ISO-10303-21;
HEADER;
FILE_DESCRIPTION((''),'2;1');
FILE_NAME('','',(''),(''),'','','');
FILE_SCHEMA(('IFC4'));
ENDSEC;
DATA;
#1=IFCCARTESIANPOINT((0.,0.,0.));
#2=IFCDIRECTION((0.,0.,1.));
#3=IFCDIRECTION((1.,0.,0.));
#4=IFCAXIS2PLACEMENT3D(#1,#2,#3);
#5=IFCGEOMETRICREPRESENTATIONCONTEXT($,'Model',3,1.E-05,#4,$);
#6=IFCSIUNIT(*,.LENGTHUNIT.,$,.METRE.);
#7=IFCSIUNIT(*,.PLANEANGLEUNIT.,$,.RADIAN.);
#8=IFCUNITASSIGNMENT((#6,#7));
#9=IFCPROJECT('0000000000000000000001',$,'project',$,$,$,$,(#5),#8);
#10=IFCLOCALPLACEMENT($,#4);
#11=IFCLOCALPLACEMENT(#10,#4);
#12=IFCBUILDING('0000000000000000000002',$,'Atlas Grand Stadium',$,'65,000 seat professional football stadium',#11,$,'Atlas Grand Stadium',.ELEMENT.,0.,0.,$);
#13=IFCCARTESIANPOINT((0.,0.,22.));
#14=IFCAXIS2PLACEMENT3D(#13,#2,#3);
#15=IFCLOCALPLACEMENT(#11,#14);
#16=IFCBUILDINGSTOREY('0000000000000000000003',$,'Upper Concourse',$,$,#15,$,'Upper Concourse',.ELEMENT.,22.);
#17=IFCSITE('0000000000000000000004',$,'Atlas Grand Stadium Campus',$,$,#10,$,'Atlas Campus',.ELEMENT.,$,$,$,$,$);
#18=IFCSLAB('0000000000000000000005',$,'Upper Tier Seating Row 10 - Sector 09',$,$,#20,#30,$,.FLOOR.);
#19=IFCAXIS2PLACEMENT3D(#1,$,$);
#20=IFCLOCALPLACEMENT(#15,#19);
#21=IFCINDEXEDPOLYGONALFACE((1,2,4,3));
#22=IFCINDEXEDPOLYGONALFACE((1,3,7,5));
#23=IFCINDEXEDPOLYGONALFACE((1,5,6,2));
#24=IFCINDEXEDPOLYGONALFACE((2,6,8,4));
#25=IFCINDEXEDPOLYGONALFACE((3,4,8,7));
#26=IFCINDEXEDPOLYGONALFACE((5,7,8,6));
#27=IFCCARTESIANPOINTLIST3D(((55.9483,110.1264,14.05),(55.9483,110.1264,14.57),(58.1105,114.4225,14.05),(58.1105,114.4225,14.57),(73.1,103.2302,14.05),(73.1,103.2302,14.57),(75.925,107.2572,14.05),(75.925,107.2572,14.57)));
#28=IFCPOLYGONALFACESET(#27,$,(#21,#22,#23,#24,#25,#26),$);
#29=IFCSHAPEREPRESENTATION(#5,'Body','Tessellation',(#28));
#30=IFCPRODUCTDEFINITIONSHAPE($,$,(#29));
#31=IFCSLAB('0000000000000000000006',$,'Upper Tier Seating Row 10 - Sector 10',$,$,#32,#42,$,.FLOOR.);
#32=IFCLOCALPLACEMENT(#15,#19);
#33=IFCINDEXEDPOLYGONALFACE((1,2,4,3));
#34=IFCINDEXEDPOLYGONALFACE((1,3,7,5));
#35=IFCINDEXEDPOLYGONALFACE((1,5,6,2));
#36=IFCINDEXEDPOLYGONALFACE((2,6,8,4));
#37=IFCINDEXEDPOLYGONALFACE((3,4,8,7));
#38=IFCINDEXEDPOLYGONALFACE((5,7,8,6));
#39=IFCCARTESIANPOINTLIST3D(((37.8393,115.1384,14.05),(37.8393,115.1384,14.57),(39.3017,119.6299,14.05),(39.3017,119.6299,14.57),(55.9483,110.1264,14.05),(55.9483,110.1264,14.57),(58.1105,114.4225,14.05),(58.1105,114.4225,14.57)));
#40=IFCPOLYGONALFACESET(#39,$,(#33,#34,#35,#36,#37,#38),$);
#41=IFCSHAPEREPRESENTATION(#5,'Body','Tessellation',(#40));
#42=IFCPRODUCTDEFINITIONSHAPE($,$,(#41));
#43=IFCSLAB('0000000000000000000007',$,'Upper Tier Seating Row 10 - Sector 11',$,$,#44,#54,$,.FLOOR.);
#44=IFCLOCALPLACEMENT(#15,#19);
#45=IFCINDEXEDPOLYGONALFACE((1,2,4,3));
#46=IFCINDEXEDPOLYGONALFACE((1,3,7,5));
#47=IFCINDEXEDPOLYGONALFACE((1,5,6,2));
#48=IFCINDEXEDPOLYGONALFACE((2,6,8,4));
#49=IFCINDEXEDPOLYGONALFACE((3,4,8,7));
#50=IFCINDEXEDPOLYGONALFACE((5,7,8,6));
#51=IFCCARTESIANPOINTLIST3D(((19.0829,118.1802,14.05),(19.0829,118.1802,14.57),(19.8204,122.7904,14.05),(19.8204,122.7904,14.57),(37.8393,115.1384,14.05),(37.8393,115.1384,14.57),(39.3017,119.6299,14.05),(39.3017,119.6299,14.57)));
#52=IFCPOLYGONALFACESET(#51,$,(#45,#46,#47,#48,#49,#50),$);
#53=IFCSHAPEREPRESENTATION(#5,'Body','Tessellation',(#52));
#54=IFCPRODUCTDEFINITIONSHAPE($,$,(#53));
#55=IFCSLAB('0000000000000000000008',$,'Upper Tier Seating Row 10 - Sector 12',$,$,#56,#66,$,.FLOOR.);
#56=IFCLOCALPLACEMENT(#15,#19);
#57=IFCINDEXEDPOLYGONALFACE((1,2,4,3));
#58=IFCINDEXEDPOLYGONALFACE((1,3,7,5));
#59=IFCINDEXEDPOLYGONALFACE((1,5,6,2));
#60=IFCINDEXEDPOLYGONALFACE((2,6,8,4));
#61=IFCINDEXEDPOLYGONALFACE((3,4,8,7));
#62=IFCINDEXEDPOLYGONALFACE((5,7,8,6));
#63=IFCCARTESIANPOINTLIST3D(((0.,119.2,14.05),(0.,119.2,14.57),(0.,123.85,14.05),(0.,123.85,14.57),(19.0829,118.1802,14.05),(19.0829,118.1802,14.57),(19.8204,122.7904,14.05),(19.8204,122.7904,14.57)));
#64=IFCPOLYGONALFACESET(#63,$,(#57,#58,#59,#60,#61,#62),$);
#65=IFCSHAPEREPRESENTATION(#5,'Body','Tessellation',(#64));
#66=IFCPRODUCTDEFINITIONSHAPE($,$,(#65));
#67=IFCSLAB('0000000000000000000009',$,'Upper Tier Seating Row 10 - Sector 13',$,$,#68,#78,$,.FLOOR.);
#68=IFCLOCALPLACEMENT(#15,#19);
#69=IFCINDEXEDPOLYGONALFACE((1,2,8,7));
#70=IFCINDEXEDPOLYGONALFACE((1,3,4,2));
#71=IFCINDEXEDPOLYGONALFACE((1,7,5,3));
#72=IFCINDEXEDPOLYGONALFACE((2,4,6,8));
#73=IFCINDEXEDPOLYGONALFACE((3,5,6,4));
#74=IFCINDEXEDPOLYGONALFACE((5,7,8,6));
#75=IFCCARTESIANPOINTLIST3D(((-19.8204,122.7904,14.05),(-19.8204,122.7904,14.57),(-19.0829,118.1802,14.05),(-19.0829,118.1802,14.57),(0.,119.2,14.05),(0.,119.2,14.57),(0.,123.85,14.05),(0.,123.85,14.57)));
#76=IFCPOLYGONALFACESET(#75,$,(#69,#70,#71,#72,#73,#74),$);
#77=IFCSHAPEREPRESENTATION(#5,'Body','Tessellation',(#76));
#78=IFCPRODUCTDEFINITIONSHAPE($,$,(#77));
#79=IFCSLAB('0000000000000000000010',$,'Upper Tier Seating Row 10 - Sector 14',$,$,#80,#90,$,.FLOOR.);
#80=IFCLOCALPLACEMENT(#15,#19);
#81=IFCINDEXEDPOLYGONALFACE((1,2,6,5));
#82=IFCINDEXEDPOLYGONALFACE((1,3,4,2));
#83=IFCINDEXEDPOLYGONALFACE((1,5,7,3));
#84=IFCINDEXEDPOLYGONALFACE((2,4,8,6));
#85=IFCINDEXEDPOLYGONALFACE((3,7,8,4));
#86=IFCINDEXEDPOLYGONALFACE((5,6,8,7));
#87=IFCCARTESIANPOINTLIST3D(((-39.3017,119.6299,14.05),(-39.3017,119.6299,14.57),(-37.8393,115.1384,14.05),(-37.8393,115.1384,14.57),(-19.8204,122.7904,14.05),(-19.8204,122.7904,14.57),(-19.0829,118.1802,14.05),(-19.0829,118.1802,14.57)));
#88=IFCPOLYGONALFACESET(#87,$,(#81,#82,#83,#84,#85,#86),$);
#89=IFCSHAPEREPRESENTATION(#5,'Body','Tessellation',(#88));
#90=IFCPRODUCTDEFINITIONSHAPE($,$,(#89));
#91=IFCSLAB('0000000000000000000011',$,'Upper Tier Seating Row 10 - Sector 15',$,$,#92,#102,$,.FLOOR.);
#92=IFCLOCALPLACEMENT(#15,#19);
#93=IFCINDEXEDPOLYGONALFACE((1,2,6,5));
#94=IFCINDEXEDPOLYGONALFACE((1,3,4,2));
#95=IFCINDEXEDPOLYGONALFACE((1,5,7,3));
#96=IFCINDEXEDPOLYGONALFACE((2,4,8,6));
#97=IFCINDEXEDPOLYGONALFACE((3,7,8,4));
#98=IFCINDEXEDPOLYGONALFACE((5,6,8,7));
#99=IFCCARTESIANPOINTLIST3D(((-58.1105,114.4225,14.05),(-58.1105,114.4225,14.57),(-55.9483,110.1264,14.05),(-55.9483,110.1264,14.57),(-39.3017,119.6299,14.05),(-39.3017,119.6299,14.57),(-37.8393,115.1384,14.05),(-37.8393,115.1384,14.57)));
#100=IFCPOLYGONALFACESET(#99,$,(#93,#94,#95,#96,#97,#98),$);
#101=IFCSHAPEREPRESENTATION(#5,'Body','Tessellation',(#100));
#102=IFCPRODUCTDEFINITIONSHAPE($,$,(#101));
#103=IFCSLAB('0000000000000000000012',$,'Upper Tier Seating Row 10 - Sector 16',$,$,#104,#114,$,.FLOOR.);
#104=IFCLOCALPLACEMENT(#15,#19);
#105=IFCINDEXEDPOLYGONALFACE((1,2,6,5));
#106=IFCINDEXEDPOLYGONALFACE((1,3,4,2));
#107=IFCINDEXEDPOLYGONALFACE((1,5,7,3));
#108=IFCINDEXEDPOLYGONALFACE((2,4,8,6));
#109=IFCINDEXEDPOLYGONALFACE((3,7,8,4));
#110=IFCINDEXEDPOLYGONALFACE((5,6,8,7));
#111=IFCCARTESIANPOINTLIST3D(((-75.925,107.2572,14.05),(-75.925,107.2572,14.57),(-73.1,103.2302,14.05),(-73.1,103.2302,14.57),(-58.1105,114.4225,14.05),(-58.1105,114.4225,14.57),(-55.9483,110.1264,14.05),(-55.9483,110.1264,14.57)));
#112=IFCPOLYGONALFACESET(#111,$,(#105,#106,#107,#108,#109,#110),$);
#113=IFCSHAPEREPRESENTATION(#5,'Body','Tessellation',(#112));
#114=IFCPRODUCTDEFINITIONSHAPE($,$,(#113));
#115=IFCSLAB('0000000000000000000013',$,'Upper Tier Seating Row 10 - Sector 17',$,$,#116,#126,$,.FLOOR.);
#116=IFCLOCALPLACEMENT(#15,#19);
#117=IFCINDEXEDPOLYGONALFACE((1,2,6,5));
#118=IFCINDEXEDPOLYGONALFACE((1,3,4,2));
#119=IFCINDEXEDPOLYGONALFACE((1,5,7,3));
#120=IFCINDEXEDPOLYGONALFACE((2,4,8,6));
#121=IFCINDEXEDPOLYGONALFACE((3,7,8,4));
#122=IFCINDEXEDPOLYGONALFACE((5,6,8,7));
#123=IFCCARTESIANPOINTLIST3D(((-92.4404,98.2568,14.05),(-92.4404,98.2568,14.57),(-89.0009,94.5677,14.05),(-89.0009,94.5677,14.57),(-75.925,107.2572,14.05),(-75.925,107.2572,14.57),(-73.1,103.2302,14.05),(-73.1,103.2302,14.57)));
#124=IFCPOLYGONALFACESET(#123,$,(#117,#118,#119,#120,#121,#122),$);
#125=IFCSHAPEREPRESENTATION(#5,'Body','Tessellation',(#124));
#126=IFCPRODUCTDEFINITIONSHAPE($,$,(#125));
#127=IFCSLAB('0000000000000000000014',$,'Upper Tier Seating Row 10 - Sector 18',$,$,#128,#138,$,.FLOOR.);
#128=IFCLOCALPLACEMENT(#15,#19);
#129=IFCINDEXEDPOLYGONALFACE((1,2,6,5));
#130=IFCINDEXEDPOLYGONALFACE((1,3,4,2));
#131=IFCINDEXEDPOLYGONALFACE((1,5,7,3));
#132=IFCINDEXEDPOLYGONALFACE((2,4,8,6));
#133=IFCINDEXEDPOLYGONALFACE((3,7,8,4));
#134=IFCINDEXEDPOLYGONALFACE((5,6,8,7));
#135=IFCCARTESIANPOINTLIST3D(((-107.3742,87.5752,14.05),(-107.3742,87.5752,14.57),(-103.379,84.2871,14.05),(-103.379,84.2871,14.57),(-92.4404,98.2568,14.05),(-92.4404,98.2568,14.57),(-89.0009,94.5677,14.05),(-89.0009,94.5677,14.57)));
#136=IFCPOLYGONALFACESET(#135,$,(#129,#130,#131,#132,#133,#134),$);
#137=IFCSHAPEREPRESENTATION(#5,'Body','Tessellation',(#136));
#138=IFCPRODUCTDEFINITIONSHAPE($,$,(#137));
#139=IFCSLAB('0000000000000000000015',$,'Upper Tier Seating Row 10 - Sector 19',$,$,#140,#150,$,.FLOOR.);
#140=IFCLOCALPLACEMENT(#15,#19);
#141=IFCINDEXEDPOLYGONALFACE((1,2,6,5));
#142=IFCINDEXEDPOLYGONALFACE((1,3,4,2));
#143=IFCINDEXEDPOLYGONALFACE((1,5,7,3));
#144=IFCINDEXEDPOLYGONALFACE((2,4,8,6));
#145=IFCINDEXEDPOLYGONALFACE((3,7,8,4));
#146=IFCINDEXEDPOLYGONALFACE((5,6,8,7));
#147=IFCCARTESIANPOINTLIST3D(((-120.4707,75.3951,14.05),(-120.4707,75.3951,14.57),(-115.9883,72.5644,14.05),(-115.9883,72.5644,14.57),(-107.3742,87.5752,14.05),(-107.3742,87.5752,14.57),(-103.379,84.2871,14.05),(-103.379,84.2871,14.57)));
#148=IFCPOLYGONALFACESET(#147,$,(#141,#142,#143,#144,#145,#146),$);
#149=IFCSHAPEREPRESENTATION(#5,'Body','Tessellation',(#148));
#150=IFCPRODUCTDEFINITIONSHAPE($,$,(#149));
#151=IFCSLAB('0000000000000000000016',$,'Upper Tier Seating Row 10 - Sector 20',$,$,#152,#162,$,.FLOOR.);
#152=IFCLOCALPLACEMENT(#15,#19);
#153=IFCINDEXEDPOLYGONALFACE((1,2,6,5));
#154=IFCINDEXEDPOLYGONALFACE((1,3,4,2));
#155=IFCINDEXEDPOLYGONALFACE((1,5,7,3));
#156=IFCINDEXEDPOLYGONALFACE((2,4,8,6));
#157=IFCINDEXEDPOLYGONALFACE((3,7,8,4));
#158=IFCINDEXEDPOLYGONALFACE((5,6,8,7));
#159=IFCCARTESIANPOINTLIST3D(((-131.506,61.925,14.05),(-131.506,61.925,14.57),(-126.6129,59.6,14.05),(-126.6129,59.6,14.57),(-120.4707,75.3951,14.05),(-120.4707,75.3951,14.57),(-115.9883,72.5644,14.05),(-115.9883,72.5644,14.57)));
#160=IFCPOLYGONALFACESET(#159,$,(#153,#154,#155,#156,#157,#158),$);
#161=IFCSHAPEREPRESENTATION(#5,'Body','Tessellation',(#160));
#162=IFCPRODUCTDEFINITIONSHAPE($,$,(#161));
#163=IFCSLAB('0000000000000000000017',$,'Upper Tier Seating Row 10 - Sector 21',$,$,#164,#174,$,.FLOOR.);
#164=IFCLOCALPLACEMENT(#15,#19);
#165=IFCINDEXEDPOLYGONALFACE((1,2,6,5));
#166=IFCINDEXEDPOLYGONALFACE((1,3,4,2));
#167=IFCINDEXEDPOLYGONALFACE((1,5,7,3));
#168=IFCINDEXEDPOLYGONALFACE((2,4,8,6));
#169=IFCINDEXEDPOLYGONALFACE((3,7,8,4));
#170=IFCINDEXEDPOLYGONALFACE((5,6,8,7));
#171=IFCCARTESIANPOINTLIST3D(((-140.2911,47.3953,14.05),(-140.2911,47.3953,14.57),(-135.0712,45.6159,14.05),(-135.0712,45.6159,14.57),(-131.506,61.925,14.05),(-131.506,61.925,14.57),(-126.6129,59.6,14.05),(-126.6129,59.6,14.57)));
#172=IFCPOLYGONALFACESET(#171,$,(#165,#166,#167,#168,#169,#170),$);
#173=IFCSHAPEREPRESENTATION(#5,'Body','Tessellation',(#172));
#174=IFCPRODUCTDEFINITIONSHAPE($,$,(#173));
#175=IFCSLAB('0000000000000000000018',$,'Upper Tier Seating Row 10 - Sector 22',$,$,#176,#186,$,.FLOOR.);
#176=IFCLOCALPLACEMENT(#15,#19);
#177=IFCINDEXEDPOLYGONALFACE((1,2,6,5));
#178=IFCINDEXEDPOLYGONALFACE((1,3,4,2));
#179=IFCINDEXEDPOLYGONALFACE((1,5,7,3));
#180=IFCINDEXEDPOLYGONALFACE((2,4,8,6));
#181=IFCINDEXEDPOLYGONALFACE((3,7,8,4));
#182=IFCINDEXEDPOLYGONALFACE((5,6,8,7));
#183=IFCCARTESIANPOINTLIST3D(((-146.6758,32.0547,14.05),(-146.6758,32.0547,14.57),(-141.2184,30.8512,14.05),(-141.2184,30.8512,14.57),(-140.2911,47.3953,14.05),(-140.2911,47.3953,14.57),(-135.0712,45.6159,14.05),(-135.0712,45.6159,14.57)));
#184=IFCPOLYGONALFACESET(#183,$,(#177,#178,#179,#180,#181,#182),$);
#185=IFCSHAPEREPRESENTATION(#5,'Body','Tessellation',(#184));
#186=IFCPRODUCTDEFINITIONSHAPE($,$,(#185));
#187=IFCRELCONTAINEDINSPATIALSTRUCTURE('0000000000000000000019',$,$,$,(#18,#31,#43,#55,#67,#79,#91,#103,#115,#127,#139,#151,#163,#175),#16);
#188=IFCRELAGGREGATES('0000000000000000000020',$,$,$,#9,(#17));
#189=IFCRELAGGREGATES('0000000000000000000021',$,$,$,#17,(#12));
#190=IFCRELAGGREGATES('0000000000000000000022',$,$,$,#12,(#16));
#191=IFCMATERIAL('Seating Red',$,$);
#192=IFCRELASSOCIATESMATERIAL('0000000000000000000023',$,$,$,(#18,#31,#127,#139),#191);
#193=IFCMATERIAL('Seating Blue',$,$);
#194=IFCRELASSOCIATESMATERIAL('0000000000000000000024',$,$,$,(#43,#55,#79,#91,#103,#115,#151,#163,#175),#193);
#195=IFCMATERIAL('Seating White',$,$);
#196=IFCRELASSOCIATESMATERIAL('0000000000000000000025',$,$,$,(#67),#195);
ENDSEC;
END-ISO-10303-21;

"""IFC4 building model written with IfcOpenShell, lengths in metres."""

from ifc_helpers import new_model, si_unit, frame, origin_with_axes, place, context, project, spatial, polyline, outline, extrude, material, element, save


model = new_model("IFC4")

# Units and contexts
model_context = context("Model", 3, precision=1e-05, world=origin_with_axes())
ifc_project = project(units=[si_unit("LENGTHUNIT", "METRE"), si_unit("PLANEANGLEUNIT", "RADIAN")], contexts=[model_context])

# Site, building, storey
site_placement = place(None, origin_with_axes())
site = spatial("IfcSite", under=ifc_project, at=site_placement, Name="Atlas Grand Stadium Campus", LongName="Atlas Campus", CompositionType="ELEMENT")
building_placement = place(site_placement, origin_with_axes())
building = spatial("IfcBuilding", under=site, at=building_placement, Name="Atlas Grand Stadium", ObjectType="65,000 seat professional football stadium", LongName="Atlas Grand Stadium", CompositionType="ELEMENT", ElevationOfRefHeight=0.0, ElevationOfTerrain=0.0)
storey_placement = place(building_placement, frame((0.0, 0.0, 22.0), z_axis=(0.0, 0.0, 1.0), x_axis=(1.0, 0.0, 0.0)))
storey = spatial("IfcBuildingStorey", under=building, at=storey_placement, Name="Upper Concourse", LongName="Upper Concourse", CompositionType="ELEMENT", Elevation=22.0)

# Slabs
ifc_material_1 = material(Name="Seating Red")
slab_1_placement = place(storey_placement, frame((0.0, 0.0, 14.05), z_axis=(0.0, 0.0, 1.0), x_axis=(1.0, 0.0, 0.0)))
element("IfcSlab", 1, at=slab_1_placement, inside=storey, material=ifc_material_1, Name="Upper Tier Seating Row 10 - Sector 09", PredefinedType="FLOOR", context=model_context, shape_type="SweptSolid", body=[
    extrude(outline(polyline([(75.925, 107.2572), (58.1105, 114.4225), (55.9483, 110.1264), (73.1, 103.2302), (75.925, 107.2572)])), origin_with_axes(), (0.0, 0.0, 1.0), 0.52),
])
slab_2_placement = place(storey_placement, frame((0.0, 0.0, 14.05), z_axis=(0.0, 0.0, 1.0), x_axis=(1.0, 0.0, 0.0)))
element("IfcSlab", 2, at=slab_2_placement, inside=storey, material=ifc_material_1, Name="Upper Tier Seating Row 10 - Sector 10", PredefinedType="FLOOR", context=model_context, shape_type="SweptSolid", body=[
    extrude(outline(polyline([(58.1105, 114.4225), (39.3017, 119.6299), (37.8393, 115.1384), (55.9483, 110.1264), (58.1105, 114.4225)])), origin_with_axes(), (0.0, 0.0, 1.0), 0.52),
])
ifc_material_2 = material(Name="Seating Blue")
slab_3_placement = place(storey_placement, frame((0.0, 0.0, 14.05), z_axis=(0.0, 0.0, 1.0), x_axis=(1.0, 0.0, 0.0)))
element("IfcSlab", 3, at=slab_3_placement, inside=storey, material=ifc_material_2, Name="Upper Tier Seating Row 10 - Sector 11", PredefinedType="FLOOR", context=model_context, shape_type="SweptSolid", body=[
    extrude(outline(polyline([(39.3017, 119.6299), (19.8204, 122.7905), (19.0829, 118.1802), (37.8393, 115.1384), (39.3017, 119.6299)])), origin_with_axes(), (0.0, 0.0, 1.0), 0.52),
])
slab_4_placement = place(storey_placement, frame((0.0, 0.0, 14.05), z_axis=(0.0, 0.0, 1.0), x_axis=(1.0, 0.0, 0.0)))
element("IfcSlab", 4, at=slab_4_placement, inside=storey, material=ifc_material_2, Name="Upper Tier Seating Row 10 - Sector 12", PredefinedType="FLOOR", context=model_context, shape_type="SweptSolid", body=[
    extrude(outline(polyline([(19.8204, 122.7905), (0.0, 123.85), (0.0, 119.2), (19.0829, 118.1802), (19.8204, 122.7905)])), origin_with_axes(), (0.0, 0.0, 1.0), 0.52),
])
ifc_material_3 = material(Name="Seating White")
slab_5_placement = place(storey_placement, frame((0.0, 0.0, 14.05), z_axis=(0.0, 0.0, 1.0), x_axis=(1.0, 0.0, 0.0)))
element("IfcSlab", 5, at=slab_5_placement, inside=storey, material=ifc_material_3, Name="Upper Tier Seating Row 10 - Sector 13", PredefinedType="FLOOR", context=model_context, shape_type="SweptSolid", body=[
    extrude(outline(polyline([(0.0, 123.85), (-19.8204, 122.7905), (-19.0829, 118.1802), (0.0, 119.2), (0.0, 123.85)])), origin_with_axes(), (0.0, 0.0, 1.0), 0.52),
])
slab_6_placement = place(storey_placement, frame((0.0, 0.0, 14.05), z_axis=(0.0, 0.0, 1.0), x_axis=(1.0, 0.0, 0.0)))
element("IfcSlab", 6, at=slab_6_placement, inside=storey, material=ifc_material_2, Name="Upper Tier Seating Row 10 - Sector 14", PredefinedType="FLOOR", context=model_context, shape_type="SweptSolid", body=[
    extrude(outline(polyline([(-19.8204, 122.7905), (-39.3017, 119.6299), (-37.8393, 115.1384), (-19.0829, 118.1802), (-19.8204, 122.7905)])), origin_with_axes(), (0.0, 0.0, 1.0), 0.52),
])
slab_7_placement = place(storey_placement, frame((0.0, 0.0, 14.05), z_axis=(0.0, 0.0, 1.0), x_axis=(1.0, 0.0, 0.0)))
element("IfcSlab", 7, at=slab_7_placement, inside=storey, material=ifc_material_2, Name="Upper Tier Seating Row 10 - Sector 15", PredefinedType="FLOOR", context=model_context, shape_type="SweptSolid", body=[
    extrude(outline(polyline([(-39.3017, 119.6299), (-58.1105, 114.4225), (-55.9483, 110.1264), (-37.8393, 115.1384), (-39.3017, 119.6299)])), origin_with_axes(), (0.0, 0.0, 1.0), 0.52),
])
slab_8_placement = place(storey_placement, frame((0.0, 0.0, 14.05), z_axis=(0.0, 0.0, 1.0), x_axis=(1.0, 0.0, 0.0)))
element("IfcSlab", 8, at=slab_8_placement, inside=storey, material=ifc_material_2, Name="Upper Tier Seating Row 10 - Sector 16", PredefinedType="FLOOR", context=model_context, shape_type="SweptSolid", body=[
    extrude(outline(polyline([(-58.1105, 114.4225), (-75.925, 107.2572), (-73.1, 103.2302), (-55.9483, 110.1264), (-58.1105, 114.4225)])), origin_with_axes(), (0.0, 0.0, 1.0), 0.52),
])
slab_9_placement = place(storey_placement, frame((0.0, 0.0, 14.05), z_axis=(0.0, 0.0, 1.0), x_axis=(1.0, 0.0, 0.0)))
element("IfcSlab", 9, at=slab_9_placement, inside=storey, material=ifc_material_2, Name="Upper Tier Seating Row 10 - Sector 17", PredefinedType="FLOOR", context=model_context, shape_type="SweptSolid", body=[
    extrude(outline(polyline([(-75.925, 107.2572), (-92.4404, 98.2568), (-89.0009, 94.5677), (-73.1, 103.2302), (-75.925, 107.2572)])), origin_with_axes(), (0.0, 0.0, 1.0), 0.52),
])
slab_10_placement = place(storey_placement, frame((0.0, 0.0, 14.05), z_axis=(0.0, 0.0, 1.0), x_axis=(1.0, 0.0, 0.0)))
element("IfcSlab", 10, at=slab_10_placement, inside=storey, material=ifc_material_1, Name="Upper Tier Seating Row 10 - Sector 18", PredefinedType="FLOOR", context=model_context, shape_type="SweptSolid", body=[
    extrude(outline(polyline([(-92.4404, 98.2568), (-107.3742, 87.5752), (-103.379, 84.2871), (-89.0009, 94.5677), (-92.4404, 98.2568)])), origin_with_axes(), (0.0, 0.0, 1.0), 0.52),
])
slab_11_placement = place(storey_placement, frame((0.0, 0.0, 14.05), z_axis=(0.0, 0.0, 1.0), x_axis=(1.0, 0.0, 0.0)))
element("IfcSlab", 11, at=slab_11_placement, inside=storey, material=ifc_material_1, Name="Upper Tier Seating Row 10 - Sector 19", PredefinedType="FLOOR", context=model_context, shape_type="SweptSolid", body=[
    extrude(outline(polyline([(-107.3742, 87.5752), (-120.4707, 75.3951), (-115.9883, 72.5644), (-103.379, 84.2871), (-107.3742, 87.5752)])), origin_with_axes(), (0.0, 0.0, 1.0), 0.52),
])
slab_12_placement = place(storey_placement, frame((0.0, 0.0, 14.05), z_axis=(0.0, 0.0, 1.0), x_axis=(1.0, 0.0, 0.0)))
element("IfcSlab", 12, at=slab_12_placement, inside=storey, material=ifc_material_2, Name="Upper Tier Seating Row 10 - Sector 20", PredefinedType="FLOOR", context=model_context, shape_type="SweptSolid", body=[
    extrude(outline(polyline([(-120.4707, 75.3951), (-131.506, 61.925), (-126.6129, 59.6), (-115.9883, 72.5644), (-120.4707, 75.3951)])), origin_with_axes(), (0.0, 0.0, 1.0), 0.52),
])
slab_13_placement = place(storey_placement, frame((0.0, 0.0, 14.05), z_axis=(0.0, 0.0, 1.0), x_axis=(1.0, 0.0, 0.0)))
element("IfcSlab", 13, at=slab_13_placement, inside=storey, material=ifc_material_2, Name="Upper Tier Seating Row 10 - Sector 21", PredefinedType="FLOOR", context=model_context, shape_type="SweptSolid", body=[
    extrude(outline(polyline([(-131.506, 61.925), (-140.2911, 47.3953), (-135.0712, 45.6159), (-126.6129, 59.6), (-131.506, 61.925)])), origin_with_axes(), (0.0, 0.0, 1.0), 0.52),
])
slab_14_placement = place(storey_placement, frame((0.0, 0.0, 14.05), z_axis=(0.0, 0.0, 1.0), x_axis=(1.0, 0.0, 0.0)))
element("IfcSlab", 14, at=slab_14_placement, inside=storey, material=ifc_material_2, Name="Upper Tier Seating Row 10 - Sector 22", PredefinedType="FLOOR", context=model_context, shape_type="SweptSolid", body=[
    extrude(outline(polyline([(-140.2911, 47.3953), (-146.6758, 32.0547), (-141.2184, 30.8512), (-135.0712, 45.6159), (-140.2911, 47.3953)])), origin_with_axes(), (0.0, 0.0, 1.0), 0.52),
])

save(model, "model.ifc")
